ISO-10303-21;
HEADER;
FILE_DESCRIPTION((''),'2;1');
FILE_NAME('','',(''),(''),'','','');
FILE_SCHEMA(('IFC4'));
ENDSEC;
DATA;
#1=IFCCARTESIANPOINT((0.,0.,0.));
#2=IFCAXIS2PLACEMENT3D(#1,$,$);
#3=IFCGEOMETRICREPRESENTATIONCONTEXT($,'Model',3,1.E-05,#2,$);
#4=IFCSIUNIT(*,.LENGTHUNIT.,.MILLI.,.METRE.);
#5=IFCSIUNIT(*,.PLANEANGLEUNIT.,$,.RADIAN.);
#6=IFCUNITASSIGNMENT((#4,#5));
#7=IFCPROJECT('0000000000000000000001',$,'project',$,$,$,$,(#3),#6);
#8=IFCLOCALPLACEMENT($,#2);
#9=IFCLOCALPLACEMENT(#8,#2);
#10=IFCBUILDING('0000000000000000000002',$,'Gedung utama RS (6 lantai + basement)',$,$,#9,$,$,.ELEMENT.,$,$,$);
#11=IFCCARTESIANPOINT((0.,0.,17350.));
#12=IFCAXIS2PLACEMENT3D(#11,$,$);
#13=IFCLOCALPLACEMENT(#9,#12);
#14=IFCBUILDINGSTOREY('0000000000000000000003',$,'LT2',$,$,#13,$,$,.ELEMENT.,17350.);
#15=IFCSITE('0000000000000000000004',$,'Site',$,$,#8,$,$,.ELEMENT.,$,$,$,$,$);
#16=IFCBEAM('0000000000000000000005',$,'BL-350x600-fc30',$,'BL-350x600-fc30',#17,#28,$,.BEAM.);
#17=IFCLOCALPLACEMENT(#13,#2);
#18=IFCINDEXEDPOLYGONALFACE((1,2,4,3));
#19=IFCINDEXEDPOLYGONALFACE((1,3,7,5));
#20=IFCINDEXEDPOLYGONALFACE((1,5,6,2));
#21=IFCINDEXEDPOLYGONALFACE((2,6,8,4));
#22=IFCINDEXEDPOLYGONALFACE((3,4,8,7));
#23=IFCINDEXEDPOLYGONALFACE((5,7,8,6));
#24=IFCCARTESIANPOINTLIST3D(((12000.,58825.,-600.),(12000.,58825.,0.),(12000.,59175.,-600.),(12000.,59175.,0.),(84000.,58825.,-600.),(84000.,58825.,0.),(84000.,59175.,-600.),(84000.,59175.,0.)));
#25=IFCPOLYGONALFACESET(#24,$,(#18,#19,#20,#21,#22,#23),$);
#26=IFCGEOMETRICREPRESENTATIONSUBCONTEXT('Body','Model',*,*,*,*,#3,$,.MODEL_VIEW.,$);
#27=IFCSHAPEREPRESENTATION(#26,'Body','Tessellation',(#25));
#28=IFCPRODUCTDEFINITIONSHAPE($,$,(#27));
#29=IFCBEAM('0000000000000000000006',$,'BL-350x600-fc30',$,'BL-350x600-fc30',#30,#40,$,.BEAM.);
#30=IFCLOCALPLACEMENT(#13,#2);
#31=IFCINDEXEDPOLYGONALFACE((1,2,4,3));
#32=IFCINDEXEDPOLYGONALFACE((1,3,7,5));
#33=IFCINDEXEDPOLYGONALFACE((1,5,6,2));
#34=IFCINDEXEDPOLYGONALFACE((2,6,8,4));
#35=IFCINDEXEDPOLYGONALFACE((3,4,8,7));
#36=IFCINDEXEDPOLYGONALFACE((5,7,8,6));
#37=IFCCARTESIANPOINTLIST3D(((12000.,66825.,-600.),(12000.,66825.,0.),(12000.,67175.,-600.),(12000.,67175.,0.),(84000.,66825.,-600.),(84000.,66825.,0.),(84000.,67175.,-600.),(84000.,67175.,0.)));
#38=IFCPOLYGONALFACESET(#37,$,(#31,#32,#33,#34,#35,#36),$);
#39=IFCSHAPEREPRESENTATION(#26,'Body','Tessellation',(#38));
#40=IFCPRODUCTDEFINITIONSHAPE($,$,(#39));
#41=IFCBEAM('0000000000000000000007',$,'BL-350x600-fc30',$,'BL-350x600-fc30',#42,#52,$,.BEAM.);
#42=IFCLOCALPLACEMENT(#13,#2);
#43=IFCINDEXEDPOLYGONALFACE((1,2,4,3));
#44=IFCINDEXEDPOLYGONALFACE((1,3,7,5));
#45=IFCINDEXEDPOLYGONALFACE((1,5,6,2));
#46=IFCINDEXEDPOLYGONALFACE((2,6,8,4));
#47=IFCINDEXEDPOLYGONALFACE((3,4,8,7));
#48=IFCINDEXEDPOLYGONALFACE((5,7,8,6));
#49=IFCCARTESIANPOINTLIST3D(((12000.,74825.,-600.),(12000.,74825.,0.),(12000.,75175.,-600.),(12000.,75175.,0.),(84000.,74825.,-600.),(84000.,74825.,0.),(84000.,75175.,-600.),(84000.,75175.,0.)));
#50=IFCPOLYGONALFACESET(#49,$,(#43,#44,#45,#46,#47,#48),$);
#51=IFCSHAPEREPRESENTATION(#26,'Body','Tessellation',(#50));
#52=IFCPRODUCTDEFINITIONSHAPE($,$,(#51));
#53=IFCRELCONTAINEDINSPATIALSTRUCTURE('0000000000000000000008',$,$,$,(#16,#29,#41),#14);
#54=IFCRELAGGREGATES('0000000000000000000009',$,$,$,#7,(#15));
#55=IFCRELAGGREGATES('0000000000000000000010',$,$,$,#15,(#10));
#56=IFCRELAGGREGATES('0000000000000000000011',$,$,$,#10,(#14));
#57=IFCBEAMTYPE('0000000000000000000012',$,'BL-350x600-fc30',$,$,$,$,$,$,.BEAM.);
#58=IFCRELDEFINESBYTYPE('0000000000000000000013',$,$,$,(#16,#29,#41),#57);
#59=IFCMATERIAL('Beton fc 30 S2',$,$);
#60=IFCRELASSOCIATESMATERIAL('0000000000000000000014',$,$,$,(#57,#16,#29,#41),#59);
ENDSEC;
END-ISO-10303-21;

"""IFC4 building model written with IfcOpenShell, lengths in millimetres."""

from ifc_helpers import new_model, si_unit, frame, origin, origin_2d, place, context, subcontext, project, spatial, rectangle, extrude, material, material_profile, profile_set, profile_usage, type_object, element, save


model = new_model("IFC4")

# Units and contexts
model_context = context("Model", 3, precision=1e-05, world=origin())
body_context = subcontext(model_context, "Body", "Model", "MODEL_VIEW")
ifc_project = project(units=[si_unit("LENGTHUNIT", "METRE", prefix="MILLI"), si_unit("PLANEANGLEUNIT", "RADIAN")], contexts=[model_context])

# Site, building, storey
site_placement = place(None, origin())
site = spatial("IfcSite", under=ifc_project, at=site_placement, Name="Site", CompositionType="ELEMENT")
building_placement = place(site_placement, origin())
building = spatial("IfcBuilding", under=site, at=building_placement, Name="Gedung utama RS (6 lantai + basement)", CompositionType="ELEMENT")
storey_placement = place(building_placement, frame((0.0, 0.0, 17350.0)))
storey = spatial("IfcBuildingStorey", under=building, at=storey_placement, Name="LT2", CompositionType="ELEMENT", Elevation=17350.0)

# Beams
ifc_material = material(Name="Beton fc 30 S2")
ifc_material_profile_1 = material_profile(ifc_material, rectangle(XDim=350.0, YDim=600.0, at=origin_2d()), Name="BL-350x600-fc30")
ifc_profile_set_1 = profile_set([ifc_material_profile_1], Name="BL-350x600-fc30")
ifc_profile_usage_1 = profile_usage(ifc_profile_set_1, cardinal=8)
beam_type = type_object("IfcBeamType", Name="BL-350x600-fc30", PredefinedType="BEAM", material=ifc_profile_set_1)
for number, where, name in (
    (1, (12000.0, 59000.0, -300.0), "BL-350x600-fc30"),
    (2, (12000.0, 67000.0, -300.0), "BL-350x600-fc30"),
    (3, (12000.0, 75000.0, -300.0), "BL-350x600-fc30"),
):
    element("IfcBeam", number, at=place(storey_placement, frame(where)), inside=storey, type_object=beam_type, material=ifc_profile_usage_1, Name=name, ObjectType="BL-350x600-fc30", PredefinedType="BEAM", context=body_context, shape_type="SweptSolid", body=[
        extrude(rectangle(XDim=350.0, YDim=600.0, at=origin_2d()), frame((0.0, 0.0, 0.0), z_axis=(1.0, 0.0, 0.0), x_axis=(0.0, 1.0, 0.0)), (0.0, 0.0, 1.0), 72000.0),
    ])

save(model, "model.ifc")
